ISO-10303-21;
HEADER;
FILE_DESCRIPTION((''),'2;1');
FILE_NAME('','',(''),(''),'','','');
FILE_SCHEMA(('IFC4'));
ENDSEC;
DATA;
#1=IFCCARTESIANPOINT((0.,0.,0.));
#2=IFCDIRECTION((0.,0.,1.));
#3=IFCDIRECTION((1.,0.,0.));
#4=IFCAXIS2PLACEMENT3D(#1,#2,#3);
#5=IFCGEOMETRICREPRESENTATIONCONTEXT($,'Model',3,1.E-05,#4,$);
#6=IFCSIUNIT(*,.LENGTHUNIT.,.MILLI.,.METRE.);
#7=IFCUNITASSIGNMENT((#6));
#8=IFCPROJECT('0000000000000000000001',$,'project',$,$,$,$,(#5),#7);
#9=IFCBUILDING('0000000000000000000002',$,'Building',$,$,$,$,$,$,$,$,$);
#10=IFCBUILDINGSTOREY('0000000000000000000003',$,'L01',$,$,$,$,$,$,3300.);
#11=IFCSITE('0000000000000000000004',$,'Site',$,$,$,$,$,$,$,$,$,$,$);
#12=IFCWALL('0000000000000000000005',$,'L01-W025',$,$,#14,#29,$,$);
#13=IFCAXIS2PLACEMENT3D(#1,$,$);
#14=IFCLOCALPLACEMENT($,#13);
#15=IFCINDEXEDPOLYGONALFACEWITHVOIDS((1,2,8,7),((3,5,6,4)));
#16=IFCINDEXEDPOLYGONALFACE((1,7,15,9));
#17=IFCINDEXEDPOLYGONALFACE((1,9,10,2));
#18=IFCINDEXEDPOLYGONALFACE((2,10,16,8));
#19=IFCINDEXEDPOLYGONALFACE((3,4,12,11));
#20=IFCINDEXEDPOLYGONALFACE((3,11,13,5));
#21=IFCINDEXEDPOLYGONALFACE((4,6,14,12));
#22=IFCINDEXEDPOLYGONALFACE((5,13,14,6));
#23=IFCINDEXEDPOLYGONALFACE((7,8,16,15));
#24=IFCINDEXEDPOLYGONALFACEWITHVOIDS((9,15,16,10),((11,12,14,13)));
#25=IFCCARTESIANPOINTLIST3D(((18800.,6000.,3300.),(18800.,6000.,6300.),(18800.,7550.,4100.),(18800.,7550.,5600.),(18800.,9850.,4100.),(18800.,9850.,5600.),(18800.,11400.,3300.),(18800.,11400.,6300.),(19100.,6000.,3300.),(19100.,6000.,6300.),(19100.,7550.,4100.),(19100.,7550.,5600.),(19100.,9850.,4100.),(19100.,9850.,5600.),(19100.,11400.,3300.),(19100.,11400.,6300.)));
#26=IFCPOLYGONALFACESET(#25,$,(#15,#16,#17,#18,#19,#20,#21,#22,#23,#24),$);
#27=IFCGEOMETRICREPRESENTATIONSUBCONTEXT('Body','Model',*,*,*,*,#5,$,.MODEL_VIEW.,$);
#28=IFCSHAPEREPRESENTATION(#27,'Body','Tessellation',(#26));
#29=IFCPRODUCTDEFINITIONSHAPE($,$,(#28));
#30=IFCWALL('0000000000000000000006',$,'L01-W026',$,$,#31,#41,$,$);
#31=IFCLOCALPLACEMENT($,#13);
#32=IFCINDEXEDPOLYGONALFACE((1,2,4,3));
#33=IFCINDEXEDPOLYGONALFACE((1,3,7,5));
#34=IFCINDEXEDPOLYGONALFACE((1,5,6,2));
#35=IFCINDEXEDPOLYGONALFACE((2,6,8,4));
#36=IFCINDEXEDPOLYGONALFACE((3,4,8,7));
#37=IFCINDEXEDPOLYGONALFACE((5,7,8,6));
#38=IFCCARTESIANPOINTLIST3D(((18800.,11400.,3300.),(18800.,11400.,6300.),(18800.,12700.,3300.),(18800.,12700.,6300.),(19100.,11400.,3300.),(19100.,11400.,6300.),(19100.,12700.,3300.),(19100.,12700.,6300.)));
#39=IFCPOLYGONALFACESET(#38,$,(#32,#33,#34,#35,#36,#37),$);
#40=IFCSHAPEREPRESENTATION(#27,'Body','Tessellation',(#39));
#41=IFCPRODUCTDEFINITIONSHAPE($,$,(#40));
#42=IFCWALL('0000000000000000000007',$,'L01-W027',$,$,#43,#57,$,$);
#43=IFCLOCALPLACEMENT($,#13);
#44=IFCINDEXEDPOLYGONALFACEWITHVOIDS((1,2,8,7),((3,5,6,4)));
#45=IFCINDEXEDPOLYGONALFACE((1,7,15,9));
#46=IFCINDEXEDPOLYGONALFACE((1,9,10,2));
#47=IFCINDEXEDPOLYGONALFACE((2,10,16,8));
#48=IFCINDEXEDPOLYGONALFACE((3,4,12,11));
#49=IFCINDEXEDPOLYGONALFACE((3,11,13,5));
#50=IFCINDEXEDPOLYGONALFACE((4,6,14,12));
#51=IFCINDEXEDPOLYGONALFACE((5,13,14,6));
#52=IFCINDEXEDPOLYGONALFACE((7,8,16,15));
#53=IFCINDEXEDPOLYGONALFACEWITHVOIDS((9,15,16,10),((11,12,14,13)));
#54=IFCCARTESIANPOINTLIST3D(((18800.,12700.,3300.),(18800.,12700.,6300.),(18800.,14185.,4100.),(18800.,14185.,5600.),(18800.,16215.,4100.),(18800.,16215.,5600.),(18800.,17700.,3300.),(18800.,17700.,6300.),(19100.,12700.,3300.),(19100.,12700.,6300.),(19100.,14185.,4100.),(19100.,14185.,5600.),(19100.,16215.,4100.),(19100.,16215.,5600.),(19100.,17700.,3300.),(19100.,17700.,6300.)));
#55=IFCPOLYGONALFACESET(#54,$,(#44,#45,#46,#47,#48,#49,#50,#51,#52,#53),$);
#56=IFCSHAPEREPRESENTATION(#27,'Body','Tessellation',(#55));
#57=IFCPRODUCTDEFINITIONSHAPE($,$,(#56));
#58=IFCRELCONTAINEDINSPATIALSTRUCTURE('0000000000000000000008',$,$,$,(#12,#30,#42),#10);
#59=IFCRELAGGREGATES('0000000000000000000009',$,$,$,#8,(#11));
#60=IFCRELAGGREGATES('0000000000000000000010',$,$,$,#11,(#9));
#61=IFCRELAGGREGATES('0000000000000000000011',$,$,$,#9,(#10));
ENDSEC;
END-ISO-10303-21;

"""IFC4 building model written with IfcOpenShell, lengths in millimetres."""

from ifc_helpers import new_model, si_unit, frame, origin_with_axes, place, context, subcontext, project, spatial, indexed_curve, outline, extrude, element, save


model = new_model("IFC4")

# Units and contexts
model_context = context("Model", 3, precision=1e-05, world=origin_with_axes())
body_context = subcontext(model_context, "Body", "Model", "MODEL_VIEW")
ifc_project = project(units=[si_unit("LENGTHUNIT", "METRE", prefix="MILLI")], contexts=[model_context])

# Site, building, storey
site = spatial("IfcSite", under=ifc_project, Name="Site")
building = spatial("IfcBuilding", under=site, Name="Building")
storey = spatial("IfcBuildingStorey", under=building, Name="L01", Elevation=3300.0)

# Wall, opening
wall_1_placement = place(None, frame((19100.0, 6000.0, 3300.0), z_axis=(0.0, 0.0, 1.0), x_axis=(0.0, 1.0, 0.0)))
wall_1 = element("IfcWall", 1, at=wall_1_placement, inside=storey, Name="L01-W025", context=body_context, shape_type="SweptSolid", body=[
    extrude(outline(indexed_curve([(0.0, 0.0), (0.0, 300.0), (5400.0, 300.0), (5400.0, 0.0), (0.0, 0.0)], self_intersect=False)), origin_with_axes(), (0.0, 0.0, 1.0), 3000.0),
])
opening_1_placement = place(wall_1_placement, frame((1550.0, -10.0, 800.0), z_axis=(0.0, 0.0, 1.0), x_axis=(1.0, 0.0, 0.0)))
element("IfcOpeningElement", 2, at=opening_1_placement, cuts=wall_1, context=body_context, shape_type="SweptSolid", body=[
    extrude(outline(indexed_curve([(0.0, 0.0), (0.0, 320.0), (2300.0, 320.0), (2300.0, 0.0), (0.0, 0.0)], self_intersect=False)), origin_with_axes(), (0.0, 0.0, 1.0), 1500.0),
])

# Wall
wall_2_placement = place(None, frame((19100.0, 11400.0, 3300.0), z_axis=(0.0, 0.0, 1.0), x_axis=(0.0, 1.0, 0.0)))
element("IfcWall", 3, at=wall_2_placement, inside=storey, Name="L01-W026", context=body_context, shape_type="SweptSolid", body=[
    extrude(outline(indexed_curve([(0.0, 0.0), (0.0, 300.0), (1300.0, 300.0), (1300.0, 0.0), (0.0, 0.0)], self_intersect=False)), origin_with_axes(), (0.0, 0.0, 1.0), 3000.0),
])

# Wall, opening
wall_3_placement = place(None, frame((19100.0, 12700.0, 3300.0), z_axis=(0.0, 0.0, 1.0), x_axis=(0.0, 1.0, 0.0)))
wall_3 = element("IfcWall", 4, at=wall_3_placement, inside=storey, Name="L01-W027", context=body_context, shape_type="SweptSolid", body=[
    extrude(outline(indexed_curve([(0.0, 0.0), (0.0, 300.0), (5000.0, 300.0), (5000.0, 0.0), (0.0, 0.0)], self_intersect=False)), origin_with_axes(), (0.0, 0.0, 1.0), 3000.0),
])
opening_2_placement = place(wall_3_placement, frame((1485.0, -10.0, 800.0), z_axis=(0.0, 0.0, 1.0), x_axis=(1.0, 0.0, 0.0)))
element("IfcOpeningElement", 5, at=opening_2_placement, cuts=wall_3, context=body_context, shape_type="SweptSolid", body=[
    extrude(outline(indexed_curve([(0.0, 0.0), (0.0, 320.0), (2030.0, 320.0), (2030.0, 0.0), (0.0, 0.0)], self_intersect=False)), origin_with_axes(), (0.0, 0.0, 1.0), 1500.0),
])

save(model, "model.ifc")
